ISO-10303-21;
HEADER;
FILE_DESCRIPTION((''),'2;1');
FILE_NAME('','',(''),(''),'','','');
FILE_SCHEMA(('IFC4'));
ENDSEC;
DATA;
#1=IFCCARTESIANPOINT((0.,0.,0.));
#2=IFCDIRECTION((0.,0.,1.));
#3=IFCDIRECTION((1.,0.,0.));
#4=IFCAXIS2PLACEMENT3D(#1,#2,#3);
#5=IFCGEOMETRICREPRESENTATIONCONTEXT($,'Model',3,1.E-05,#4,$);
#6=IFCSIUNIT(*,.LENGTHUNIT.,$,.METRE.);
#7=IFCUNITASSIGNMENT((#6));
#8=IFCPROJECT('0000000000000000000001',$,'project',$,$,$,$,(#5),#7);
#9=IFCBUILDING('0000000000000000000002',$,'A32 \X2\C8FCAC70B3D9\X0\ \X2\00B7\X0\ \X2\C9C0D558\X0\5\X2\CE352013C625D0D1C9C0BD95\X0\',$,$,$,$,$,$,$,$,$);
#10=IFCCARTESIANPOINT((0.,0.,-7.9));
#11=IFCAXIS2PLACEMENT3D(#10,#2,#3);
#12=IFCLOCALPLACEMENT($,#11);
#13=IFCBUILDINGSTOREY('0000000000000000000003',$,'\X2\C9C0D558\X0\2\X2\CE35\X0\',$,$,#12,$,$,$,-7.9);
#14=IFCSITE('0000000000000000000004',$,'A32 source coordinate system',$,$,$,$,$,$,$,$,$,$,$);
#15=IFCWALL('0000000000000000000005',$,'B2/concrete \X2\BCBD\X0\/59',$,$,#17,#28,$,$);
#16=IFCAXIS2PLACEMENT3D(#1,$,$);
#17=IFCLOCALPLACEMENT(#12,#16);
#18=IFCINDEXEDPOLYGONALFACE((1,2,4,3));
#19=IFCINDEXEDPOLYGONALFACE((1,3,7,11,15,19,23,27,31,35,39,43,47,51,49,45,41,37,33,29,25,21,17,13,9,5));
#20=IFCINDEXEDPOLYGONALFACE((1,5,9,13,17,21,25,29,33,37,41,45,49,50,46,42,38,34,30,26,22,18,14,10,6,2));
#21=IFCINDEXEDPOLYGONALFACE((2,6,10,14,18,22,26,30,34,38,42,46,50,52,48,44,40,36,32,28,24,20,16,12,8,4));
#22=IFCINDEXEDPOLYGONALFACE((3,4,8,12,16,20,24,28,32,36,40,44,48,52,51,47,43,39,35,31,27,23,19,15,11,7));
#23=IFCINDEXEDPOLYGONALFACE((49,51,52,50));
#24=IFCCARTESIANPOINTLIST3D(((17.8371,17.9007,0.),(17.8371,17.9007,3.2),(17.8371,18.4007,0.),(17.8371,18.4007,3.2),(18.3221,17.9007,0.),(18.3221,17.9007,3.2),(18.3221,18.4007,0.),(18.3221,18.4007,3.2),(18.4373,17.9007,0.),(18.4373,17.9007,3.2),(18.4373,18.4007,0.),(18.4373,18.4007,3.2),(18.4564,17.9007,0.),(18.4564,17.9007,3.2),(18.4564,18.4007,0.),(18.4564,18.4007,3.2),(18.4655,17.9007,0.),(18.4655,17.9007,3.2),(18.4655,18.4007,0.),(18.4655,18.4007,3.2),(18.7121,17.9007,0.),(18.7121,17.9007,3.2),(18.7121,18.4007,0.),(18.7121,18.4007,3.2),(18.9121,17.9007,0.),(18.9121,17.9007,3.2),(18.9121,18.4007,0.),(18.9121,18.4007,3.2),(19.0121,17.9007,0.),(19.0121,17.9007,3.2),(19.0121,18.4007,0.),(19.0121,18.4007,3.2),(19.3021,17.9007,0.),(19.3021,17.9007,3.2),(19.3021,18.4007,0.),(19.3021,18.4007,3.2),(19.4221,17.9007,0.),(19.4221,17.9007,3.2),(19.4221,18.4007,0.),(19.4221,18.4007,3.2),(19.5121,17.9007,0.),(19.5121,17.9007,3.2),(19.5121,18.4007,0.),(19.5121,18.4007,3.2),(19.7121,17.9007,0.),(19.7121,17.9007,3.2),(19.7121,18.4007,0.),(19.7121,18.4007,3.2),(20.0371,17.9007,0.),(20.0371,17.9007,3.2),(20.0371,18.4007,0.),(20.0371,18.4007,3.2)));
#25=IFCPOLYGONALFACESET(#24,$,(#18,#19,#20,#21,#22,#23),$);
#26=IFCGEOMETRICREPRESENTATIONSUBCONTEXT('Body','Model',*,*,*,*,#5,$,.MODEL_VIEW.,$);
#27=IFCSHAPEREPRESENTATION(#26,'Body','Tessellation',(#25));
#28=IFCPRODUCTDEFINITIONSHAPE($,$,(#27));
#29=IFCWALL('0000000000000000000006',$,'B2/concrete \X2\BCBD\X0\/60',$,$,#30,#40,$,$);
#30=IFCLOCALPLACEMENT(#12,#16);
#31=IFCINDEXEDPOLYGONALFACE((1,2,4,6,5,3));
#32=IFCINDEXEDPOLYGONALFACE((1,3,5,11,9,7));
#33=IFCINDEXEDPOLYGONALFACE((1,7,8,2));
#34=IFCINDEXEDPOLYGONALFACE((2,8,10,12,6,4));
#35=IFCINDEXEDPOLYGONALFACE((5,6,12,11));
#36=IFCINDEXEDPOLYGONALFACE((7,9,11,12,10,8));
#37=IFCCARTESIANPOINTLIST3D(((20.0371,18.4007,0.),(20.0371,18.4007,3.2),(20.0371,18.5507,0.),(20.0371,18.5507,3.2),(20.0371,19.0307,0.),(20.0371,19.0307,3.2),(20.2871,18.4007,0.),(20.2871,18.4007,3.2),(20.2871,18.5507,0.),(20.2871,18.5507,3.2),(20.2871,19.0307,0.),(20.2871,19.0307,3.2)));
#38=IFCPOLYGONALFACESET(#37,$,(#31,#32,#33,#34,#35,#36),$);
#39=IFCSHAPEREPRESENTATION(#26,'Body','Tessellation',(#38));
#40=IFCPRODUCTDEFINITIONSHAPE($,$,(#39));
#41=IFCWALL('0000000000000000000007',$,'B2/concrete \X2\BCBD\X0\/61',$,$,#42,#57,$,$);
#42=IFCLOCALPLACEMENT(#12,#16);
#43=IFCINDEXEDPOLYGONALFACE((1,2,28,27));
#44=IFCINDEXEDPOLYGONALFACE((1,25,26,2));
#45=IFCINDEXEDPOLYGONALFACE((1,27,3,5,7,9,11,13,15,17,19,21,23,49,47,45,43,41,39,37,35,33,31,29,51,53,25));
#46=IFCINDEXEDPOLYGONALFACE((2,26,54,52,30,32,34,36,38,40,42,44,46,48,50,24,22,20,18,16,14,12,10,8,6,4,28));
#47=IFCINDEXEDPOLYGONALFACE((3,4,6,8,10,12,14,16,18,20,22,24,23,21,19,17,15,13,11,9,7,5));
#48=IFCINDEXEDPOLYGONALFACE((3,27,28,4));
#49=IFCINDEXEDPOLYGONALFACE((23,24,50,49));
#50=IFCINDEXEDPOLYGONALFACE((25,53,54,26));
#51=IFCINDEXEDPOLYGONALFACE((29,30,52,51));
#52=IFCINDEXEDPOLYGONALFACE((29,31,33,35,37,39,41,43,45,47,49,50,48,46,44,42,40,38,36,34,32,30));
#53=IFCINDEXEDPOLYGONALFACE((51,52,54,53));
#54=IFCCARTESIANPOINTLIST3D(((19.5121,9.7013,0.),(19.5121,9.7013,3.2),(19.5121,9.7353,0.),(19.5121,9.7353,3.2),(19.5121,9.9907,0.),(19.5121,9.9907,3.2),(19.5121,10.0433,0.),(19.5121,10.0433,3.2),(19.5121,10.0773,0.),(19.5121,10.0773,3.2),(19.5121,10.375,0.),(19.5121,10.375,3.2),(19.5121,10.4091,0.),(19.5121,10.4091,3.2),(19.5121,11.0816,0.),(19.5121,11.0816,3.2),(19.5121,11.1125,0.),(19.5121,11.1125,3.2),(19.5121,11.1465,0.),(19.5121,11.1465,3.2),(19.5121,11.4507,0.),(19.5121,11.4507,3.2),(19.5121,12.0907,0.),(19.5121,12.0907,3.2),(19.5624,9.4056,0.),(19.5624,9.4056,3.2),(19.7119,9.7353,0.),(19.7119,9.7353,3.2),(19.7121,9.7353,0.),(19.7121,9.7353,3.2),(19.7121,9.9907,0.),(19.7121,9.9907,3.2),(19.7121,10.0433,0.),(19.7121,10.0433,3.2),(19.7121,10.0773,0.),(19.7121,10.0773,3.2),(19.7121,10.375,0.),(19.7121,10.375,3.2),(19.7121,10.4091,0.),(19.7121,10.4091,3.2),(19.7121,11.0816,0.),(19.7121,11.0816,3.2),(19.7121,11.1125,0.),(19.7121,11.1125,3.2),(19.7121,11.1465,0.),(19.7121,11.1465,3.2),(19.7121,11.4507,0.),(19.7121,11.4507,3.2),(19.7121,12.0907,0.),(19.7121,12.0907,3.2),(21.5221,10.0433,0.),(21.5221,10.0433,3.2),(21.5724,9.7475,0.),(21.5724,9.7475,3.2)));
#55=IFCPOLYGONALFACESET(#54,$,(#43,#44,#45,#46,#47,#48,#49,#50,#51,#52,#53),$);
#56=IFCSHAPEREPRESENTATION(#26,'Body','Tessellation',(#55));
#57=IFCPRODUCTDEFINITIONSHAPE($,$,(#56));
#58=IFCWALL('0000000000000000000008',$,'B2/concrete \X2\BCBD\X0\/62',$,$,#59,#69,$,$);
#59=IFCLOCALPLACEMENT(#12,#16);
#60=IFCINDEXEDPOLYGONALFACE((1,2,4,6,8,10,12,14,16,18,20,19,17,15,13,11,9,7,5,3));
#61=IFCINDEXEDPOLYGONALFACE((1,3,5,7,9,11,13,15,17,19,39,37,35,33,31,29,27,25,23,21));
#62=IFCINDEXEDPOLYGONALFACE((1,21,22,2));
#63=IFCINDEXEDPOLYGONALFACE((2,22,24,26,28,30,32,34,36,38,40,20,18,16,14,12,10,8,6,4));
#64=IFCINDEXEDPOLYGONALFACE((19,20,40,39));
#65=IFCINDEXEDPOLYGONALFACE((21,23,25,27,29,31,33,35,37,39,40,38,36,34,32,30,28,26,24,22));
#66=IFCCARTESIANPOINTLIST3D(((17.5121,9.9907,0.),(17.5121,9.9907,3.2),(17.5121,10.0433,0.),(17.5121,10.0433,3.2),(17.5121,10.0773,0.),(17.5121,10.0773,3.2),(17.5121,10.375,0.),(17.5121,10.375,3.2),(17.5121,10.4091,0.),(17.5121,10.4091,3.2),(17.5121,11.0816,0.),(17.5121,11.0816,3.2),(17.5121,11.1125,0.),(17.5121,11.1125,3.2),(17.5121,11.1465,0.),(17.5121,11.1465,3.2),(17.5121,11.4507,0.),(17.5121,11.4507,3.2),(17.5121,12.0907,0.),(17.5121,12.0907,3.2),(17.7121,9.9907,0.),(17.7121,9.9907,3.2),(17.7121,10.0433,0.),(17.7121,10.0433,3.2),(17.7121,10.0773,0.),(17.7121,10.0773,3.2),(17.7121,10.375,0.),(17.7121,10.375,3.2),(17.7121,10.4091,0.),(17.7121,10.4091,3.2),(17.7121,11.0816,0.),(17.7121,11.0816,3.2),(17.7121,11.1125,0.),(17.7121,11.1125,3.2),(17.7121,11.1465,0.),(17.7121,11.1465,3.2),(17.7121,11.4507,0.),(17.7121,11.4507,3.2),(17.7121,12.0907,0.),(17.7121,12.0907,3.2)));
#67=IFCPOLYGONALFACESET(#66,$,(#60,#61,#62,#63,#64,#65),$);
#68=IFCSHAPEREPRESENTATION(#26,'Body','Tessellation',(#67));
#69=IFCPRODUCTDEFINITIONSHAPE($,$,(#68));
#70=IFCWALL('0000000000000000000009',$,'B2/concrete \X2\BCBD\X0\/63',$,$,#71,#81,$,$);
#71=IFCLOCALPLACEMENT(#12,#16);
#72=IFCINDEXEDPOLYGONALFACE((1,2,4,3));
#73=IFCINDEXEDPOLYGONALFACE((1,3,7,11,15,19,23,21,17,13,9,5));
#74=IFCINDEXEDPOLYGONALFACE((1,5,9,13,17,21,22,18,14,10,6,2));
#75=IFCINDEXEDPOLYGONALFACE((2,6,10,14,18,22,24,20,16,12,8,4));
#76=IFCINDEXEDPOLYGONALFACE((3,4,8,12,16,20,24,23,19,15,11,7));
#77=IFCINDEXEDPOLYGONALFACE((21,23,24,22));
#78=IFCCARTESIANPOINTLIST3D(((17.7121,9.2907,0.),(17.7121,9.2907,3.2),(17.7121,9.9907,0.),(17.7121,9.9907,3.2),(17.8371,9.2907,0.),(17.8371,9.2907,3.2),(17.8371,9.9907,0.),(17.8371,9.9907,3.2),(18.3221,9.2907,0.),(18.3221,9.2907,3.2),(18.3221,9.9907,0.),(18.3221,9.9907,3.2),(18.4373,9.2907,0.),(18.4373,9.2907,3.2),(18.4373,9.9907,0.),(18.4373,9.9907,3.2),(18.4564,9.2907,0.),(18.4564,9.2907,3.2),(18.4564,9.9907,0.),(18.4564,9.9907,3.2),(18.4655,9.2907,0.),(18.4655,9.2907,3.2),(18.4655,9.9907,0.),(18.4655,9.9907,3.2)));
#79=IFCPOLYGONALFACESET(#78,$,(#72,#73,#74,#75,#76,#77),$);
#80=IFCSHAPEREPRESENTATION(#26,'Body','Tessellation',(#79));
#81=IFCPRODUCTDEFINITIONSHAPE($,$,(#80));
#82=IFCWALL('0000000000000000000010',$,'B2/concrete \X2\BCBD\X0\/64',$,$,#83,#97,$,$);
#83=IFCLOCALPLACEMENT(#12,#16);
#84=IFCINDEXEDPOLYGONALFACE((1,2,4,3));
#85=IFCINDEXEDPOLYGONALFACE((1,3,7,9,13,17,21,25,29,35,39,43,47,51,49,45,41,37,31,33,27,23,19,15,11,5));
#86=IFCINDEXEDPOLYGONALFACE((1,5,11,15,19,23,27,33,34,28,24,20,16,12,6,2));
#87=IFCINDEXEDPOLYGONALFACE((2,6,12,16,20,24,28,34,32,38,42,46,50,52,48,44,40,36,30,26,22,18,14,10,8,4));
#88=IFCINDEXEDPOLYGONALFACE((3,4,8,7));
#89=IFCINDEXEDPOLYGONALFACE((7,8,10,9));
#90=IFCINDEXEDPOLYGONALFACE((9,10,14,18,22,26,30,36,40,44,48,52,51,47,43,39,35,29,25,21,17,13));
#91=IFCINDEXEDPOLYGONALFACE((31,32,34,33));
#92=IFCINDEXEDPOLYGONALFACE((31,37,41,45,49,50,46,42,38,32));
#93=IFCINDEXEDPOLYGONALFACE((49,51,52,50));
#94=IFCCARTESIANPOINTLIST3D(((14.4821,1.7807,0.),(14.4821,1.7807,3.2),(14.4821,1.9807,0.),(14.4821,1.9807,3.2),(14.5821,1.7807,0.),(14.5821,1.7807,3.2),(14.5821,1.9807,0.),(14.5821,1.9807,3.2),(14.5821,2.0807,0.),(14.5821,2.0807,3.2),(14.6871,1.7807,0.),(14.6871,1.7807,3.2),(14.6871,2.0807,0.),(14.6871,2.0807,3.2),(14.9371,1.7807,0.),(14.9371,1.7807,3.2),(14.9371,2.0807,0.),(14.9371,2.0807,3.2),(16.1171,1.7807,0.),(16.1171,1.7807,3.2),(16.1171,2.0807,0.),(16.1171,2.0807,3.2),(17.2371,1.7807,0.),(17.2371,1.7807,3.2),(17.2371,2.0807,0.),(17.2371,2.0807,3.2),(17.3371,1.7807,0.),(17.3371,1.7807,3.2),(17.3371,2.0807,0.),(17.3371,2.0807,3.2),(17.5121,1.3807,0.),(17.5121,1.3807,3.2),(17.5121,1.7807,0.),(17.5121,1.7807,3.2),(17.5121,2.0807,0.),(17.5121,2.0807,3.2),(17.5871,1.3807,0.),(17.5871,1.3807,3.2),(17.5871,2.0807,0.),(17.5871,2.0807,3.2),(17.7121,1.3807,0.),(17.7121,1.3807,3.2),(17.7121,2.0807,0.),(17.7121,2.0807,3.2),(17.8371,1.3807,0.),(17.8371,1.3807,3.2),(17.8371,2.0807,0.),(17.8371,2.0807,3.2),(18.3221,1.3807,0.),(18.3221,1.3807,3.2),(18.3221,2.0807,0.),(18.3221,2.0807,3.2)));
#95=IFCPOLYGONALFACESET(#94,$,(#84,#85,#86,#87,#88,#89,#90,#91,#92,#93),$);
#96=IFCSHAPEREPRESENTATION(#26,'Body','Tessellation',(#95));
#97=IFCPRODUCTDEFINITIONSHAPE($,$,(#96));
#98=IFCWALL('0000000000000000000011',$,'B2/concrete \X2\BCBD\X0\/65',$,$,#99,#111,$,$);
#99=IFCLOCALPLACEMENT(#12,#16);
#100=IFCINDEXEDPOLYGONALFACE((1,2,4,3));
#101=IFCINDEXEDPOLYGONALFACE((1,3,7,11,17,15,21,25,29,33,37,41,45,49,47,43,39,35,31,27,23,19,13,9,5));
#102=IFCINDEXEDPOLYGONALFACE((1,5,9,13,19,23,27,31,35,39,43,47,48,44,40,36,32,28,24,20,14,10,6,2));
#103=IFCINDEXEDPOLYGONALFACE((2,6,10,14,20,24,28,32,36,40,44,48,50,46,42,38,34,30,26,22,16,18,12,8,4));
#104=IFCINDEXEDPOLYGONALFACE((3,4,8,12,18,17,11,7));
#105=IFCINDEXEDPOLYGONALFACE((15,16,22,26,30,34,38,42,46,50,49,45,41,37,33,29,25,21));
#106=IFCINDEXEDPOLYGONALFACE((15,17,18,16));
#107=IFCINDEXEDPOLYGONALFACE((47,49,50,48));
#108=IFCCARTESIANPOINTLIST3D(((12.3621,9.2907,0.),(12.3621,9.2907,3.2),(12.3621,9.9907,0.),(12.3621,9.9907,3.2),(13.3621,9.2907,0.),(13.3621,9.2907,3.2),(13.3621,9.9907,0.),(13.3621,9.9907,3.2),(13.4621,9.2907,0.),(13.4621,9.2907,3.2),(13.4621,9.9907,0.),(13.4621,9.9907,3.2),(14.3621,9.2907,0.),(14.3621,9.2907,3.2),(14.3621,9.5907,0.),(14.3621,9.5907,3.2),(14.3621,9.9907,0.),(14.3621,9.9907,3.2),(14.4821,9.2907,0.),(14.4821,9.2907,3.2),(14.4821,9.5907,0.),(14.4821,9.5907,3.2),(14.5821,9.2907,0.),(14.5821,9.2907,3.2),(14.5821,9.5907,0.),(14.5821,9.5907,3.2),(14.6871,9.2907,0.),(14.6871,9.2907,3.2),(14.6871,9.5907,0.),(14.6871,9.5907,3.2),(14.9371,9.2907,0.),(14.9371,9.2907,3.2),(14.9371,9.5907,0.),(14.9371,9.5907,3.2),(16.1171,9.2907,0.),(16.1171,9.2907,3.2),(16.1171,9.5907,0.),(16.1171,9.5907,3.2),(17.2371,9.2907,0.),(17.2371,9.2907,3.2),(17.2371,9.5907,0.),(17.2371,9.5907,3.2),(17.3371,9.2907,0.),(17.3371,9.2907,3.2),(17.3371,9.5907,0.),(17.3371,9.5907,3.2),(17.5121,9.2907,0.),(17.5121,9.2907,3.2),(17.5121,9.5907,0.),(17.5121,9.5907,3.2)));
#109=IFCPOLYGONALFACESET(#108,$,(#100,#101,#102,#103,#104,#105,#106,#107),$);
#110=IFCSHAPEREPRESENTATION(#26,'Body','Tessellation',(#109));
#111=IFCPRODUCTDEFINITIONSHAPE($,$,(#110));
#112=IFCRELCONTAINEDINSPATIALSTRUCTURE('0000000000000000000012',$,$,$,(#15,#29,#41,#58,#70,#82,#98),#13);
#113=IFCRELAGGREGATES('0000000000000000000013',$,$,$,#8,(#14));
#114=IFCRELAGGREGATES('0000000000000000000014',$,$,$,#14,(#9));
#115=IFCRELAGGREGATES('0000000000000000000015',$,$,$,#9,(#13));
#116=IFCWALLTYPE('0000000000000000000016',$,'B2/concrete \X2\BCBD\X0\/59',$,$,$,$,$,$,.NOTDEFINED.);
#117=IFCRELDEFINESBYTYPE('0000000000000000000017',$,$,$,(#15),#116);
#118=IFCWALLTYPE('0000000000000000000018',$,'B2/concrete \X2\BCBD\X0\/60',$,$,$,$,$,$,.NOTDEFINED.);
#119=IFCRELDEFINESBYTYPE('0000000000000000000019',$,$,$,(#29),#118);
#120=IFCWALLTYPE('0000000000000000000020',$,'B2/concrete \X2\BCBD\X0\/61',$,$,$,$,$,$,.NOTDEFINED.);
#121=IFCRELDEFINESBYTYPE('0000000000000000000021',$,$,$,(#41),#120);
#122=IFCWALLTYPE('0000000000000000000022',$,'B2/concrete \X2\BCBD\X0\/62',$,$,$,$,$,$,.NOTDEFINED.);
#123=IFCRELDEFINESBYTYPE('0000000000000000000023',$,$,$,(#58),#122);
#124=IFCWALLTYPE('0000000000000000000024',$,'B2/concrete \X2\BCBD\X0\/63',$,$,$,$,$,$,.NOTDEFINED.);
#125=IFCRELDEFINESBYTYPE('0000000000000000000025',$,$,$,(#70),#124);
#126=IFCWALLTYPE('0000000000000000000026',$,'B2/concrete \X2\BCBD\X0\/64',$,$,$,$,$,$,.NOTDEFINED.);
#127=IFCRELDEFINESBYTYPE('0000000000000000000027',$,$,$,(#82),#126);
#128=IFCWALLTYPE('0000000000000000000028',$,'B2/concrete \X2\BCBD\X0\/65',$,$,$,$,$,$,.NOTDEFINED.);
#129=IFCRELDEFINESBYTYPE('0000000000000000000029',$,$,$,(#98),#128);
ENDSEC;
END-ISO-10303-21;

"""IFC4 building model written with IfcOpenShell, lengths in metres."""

from ifc_helpers import new_model, si_unit, frame, origin, origin_with_axes, place, context, subcontext, project, spatial, polyline, outline, extrude, source, transform, mapped, type_object, type_shapes, element, save


model = new_model("IFC4")

# Units and contexts
model_context = context("Model", 3, precision=1e-05, world=origin_with_axes())
body_context = subcontext(model_context, "Body", "Model", "MODEL_VIEW")
ifc_project = project(units=[si_unit("LENGTHUNIT", "METRE")], contexts=[model_context])

# Site, building, storey
site = spatial("IfcSite", under=ifc_project, Name="A32 source coordinate system")
building = spatial("IfcBuilding", under=site, Name="A32 주거동 · 지하5층–옥탑지붕")
storey_placement = place(None, frame((0.0, 0.0, -7.9), z_axis=(0.0, 0.0, 1.0), x_axis=(1.0, 0.0, 0.0)))
storey = spatial("IfcBuildingStorey", under=building, at=storey_placement, Name="지하2층", Elevation=-7.9)

# Walls
wall_type_1 = type_object("IfcWallType", Name="B2/concrete 벽/59", PredefinedType="NOTDEFINED")
shared_shape_1 = source(origin(), body_context, "Body", "SweptSolid", [
    extrude(outline(polyline([(18.4373, 18.4007), (18.4564, 18.4007), (18.4655, 18.4007), (18.7121, 18.4007), (18.9121, 18.4007), (19.0121, 18.4007), (19.3021, 18.4007), (19.4221, 18.4007), (19.5121, 18.4007), (19.7121, 18.4007), (20.0371, 18.4007), (20.0371, 17.9007), (19.7121, 17.9007), (19.5121, 17.9007), (19.4221, 17.9007), (19.3021, 17.9007), (19.0121, 17.9007), (18.9121, 17.9007), (18.7121, 17.9007), (18.4655, 17.9007), (18.4564, 17.9007), (18.4373, 17.9007), (18.3221, 17.9007), (17.8371, 17.9007), (17.8371, 18.4007), (18.3221, 18.4007), (18.4373, 18.4007)])), origin(), (0.0, 0.0, 1.0), 3.2),
])
type_shapes(wall_type_1, [shared_shape_1])
wall_1_placement = place(storey_placement, origin_with_axes())
element("IfcWall", 1, at=wall_1_placement, inside=storey, type_object=wall_type_1, Name="B2/concrete 벽/59", context=body_context, shape_type="MappedRepresentation", body=[
    mapped(shared_shape_1, transform((0.0, 0.0, 0.0), scale=1.0)),
])
wall_type_2 = type_object("IfcWallType", Name="B2/concrete 벽/60", PredefinedType="NOTDEFINED")
shared_shape_2 = source(origin(), body_context, "Body", "SweptSolid", [
    extrude(outline(polyline([(20.2871, 19.0307), (20.2871, 18.5507), (20.2871, 18.4007), (20.0371, 18.4007), (20.0371, 18.5507), (20.0371, 19.0307), (20.2871, 19.0307)])), origin(), (0.0, 0.0, 1.0), 3.2),
])
type_shapes(wall_type_2, [shared_shape_2])
wall_2_placement = place(storey_placement, origin_with_axes())
element("IfcWall", 2, at=wall_2_placement, inside=storey, type_object=wall_type_2, Name="B2/concrete 벽/60", context=body_context, shape_type="MappedRepresentation", body=[
    mapped(shared_shape_2, transform((0.0, 0.0, 0.0), scale=1.0)),
])
wall_type_3 = type_object("IfcWallType", Name="B2/concrete 벽/61", PredefinedType="NOTDEFINED")
shared_shape_3 = source(origin(), body_context, "Body", "SweptSolid", [
    extrude(outline(polyline([(19.5121, 11.1465), (19.5121, 11.4507), (19.5121, 12.0907), (19.7121, 12.0907), (19.7121, 11.4507), (19.7121, 11.1465), (19.7121, 11.1125), (19.7121, 11.0816), (19.7121, 10.4091), (19.7121, 10.375), (19.7121, 10.0773), (19.7121, 10.0433), (19.7121, 9.9907), (19.7121, 9.7353), (21.5221, 10.0433), (21.5724, 9.7475), (19.5624, 9.4056), (19.5121, 9.7013), (19.7119, 9.7353), (19.5121, 9.7353), (19.5121, 9.9907), (19.5121, 10.0433), (19.5121, 10.0773), (19.5121, 10.375), (19.5121, 10.4091), (19.5121, 11.0816), (19.5121, 11.1125), (19.5121, 11.1465)])), origin(), (0.0, 0.0, 1.0), 3.2),
])
type_shapes(wall_type_3, [shared_shape_3])
wall_3_placement = place(storey_placement, origin_with_axes())
element("IfcWall", 3, at=wall_3_placement, inside=storey, type_object=wall_type_3, Name="B2/concrete 벽/61", context=body_context, shape_type="MappedRepresentation", body=[
    mapped(shared_shape_3, transform((0.0, 0.0, 0.0), scale=1.0)),
])
wall_type_4 = type_object("IfcWallType", Name="B2/concrete 벽/62", PredefinedType="NOTDEFINED")
shared_shape_4 = source(origin(), body_context, "Body", "SweptSolid", [
    extrude(outline(polyline([(17.5121, 12.0907), (17.7121, 12.0907), (17.7121, 11.4507), (17.7121, 11.1465), (17.7121, 11.1125), (17.7121, 11.0816), (17.7121, 10.4091), (17.7121, 10.375), (17.7121, 10.0773), (17.7121, 10.0433), (17.7121, 9.9907), (17.5121, 9.9907), (17.5121, 10.0433), (17.5121, 10.0773), (17.5121, 10.375), (17.5121, 10.4091), (17.5121, 11.0816), (17.5121, 11.1125), (17.5121, 11.1465), (17.5121, 11.4507), (17.5121, 12.0907)])), origin(), (0.0, 0.0, 1.0), 3.2),
])
type_shapes(wall_type_4, [shared_shape_4])
wall_4_placement = place(storey_placement, origin_with_axes())
element("IfcWall", 4, at=wall_4_placement, inside=storey, type_object=wall_type_4, Name="B2/concrete 벽/62", context=body_context, shape_type="MappedRepresentation", body=[
    mapped(shared_shape_4, transform((0.0, 0.0, 0.0), scale=1.0)),
])
wall_type_5 = type_object("IfcWallType", Name="B2/concrete 벽/63", PredefinedType="NOTDEFINED")
shared_shape_5 = source(origin(), body_context, "Body", "SweptSolid", [
    extrude(outline(polyline([(18.4373, 9.9907), (18.4564, 9.9907), (18.4655, 9.9907), (18.4655, 9.2907), (18.4564, 9.2907), (18.4373, 9.2907), (18.3221, 9.2907), (17.8371, 9.2907), (17.7121, 9.2907), (17.7121, 9.9907), (17.8371, 9.9907), (18.3221, 9.9907), (18.4373, 9.9907)])), origin(), (0.0, 0.0, 1.0), 3.2),
])
type_shapes(wall_type_5, [shared_shape_5])
wall_5_placement = place(storey_placement, origin_with_axes())
element("IfcWall", 5, at=wall_5_placement, inside=storey, type_object=wall_type_5, Name="B2/concrete 벽/63", context=body_context, shape_type="MappedRepresentation", body=[
    mapped(shared_shape_5, transform((0.0, 0.0, 0.0), scale=1.0)),
])
wall_type_6 = type_object("IfcWallType", Name="B2/concrete 벽/64", PredefinedType="NOTDEFINED")
shared_shape_6 = source(origin(), body_context, "Body", "SweptSolid", [
    extrude(outline(polyline([(14.5821, 2.0807), (14.6871, 2.0807), (14.9371, 2.0807), (16.1171, 2.0807), (17.2371, 2.0807), (17.3371, 2.0807), (17.5121, 2.0807), (17.5871, 2.0807), (17.7121, 2.0807), (17.8371, 2.0807), (18.3221, 2.0807), (18.3221, 1.3807), (17.8371, 1.3807), (17.7121, 1.3807), (17.5871, 1.3807), (17.5121, 1.3807), (17.5121, 1.7807), (17.3371, 1.7807), (17.2371, 1.7807), (16.1171, 1.7807), (14.9371, 1.7807), (14.6871, 1.7807), (14.5821, 1.7807), (14.4821, 1.7807), (14.4821, 1.9807), (14.5821, 1.9807), (14.5821, 2.0807)])), origin(), (0.0, 0.0, 1.0), 3.2),
])
type_shapes(wall_type_6, [shared_shape_6])
wall_6_placement = place(storey_placement, origin_with_axes())
element("IfcWall", 6, at=wall_6_placement, inside=storey, type_object=wall_type_6, Name="B2/concrete 벽/64", context=body_context, shape_type="MappedRepresentation", body=[
    mapped(shared_shape_6, transform((0.0, 0.0, 0.0), scale=1.0)),
])
wall_type_7 = type_object("IfcWallType", Name="B2/concrete 벽/65", PredefinedType="NOTDEFINED")
shared_shape_7 = source(origin(), body_context, "Body", "SweptSolid", [
    extrude(outline(polyline([(14.3621, 9.5907), (14.4821, 9.5907), (14.5821, 9.5907), (14.6871, 9.5907), (14.9371, 9.5907), (16.1171, 9.5907), (17.2371, 9.5907), (17.3371, 9.5907), (17.5121, 9.5907), (17.5121, 9.2907), (17.3371, 9.2907), (17.2371, 9.2907), (16.1171, 9.2907), (14.9371, 9.2907), (14.6871, 9.2907), (14.5821, 9.2907), (14.4821, 9.2907), (14.3621, 9.2907), (13.4621, 9.2907), (13.3621, 9.2907), (12.3621, 9.2907), (12.3621, 9.9907), (13.3621, 9.9907), (13.4621, 9.9907), (14.3621, 9.9907), (14.3621, 9.5907)])), origin(), (0.0, 0.0, 1.0), 3.2),
])
type_shapes(wall_type_7, [shared_shape_7])
wall_7_placement = place(storey_placement, origin_with_axes())
element("IfcWall", 7, at=wall_7_placement, inside=storey, type_object=wall_type_7, Name="B2/concrete 벽/65", context=body_context, shape_type="MappedRepresentation", body=[
    mapped(shared_shape_7, transform((0.0, 0.0, 0.0), scale=1.0)),
])

save(model, "model.ifc")
